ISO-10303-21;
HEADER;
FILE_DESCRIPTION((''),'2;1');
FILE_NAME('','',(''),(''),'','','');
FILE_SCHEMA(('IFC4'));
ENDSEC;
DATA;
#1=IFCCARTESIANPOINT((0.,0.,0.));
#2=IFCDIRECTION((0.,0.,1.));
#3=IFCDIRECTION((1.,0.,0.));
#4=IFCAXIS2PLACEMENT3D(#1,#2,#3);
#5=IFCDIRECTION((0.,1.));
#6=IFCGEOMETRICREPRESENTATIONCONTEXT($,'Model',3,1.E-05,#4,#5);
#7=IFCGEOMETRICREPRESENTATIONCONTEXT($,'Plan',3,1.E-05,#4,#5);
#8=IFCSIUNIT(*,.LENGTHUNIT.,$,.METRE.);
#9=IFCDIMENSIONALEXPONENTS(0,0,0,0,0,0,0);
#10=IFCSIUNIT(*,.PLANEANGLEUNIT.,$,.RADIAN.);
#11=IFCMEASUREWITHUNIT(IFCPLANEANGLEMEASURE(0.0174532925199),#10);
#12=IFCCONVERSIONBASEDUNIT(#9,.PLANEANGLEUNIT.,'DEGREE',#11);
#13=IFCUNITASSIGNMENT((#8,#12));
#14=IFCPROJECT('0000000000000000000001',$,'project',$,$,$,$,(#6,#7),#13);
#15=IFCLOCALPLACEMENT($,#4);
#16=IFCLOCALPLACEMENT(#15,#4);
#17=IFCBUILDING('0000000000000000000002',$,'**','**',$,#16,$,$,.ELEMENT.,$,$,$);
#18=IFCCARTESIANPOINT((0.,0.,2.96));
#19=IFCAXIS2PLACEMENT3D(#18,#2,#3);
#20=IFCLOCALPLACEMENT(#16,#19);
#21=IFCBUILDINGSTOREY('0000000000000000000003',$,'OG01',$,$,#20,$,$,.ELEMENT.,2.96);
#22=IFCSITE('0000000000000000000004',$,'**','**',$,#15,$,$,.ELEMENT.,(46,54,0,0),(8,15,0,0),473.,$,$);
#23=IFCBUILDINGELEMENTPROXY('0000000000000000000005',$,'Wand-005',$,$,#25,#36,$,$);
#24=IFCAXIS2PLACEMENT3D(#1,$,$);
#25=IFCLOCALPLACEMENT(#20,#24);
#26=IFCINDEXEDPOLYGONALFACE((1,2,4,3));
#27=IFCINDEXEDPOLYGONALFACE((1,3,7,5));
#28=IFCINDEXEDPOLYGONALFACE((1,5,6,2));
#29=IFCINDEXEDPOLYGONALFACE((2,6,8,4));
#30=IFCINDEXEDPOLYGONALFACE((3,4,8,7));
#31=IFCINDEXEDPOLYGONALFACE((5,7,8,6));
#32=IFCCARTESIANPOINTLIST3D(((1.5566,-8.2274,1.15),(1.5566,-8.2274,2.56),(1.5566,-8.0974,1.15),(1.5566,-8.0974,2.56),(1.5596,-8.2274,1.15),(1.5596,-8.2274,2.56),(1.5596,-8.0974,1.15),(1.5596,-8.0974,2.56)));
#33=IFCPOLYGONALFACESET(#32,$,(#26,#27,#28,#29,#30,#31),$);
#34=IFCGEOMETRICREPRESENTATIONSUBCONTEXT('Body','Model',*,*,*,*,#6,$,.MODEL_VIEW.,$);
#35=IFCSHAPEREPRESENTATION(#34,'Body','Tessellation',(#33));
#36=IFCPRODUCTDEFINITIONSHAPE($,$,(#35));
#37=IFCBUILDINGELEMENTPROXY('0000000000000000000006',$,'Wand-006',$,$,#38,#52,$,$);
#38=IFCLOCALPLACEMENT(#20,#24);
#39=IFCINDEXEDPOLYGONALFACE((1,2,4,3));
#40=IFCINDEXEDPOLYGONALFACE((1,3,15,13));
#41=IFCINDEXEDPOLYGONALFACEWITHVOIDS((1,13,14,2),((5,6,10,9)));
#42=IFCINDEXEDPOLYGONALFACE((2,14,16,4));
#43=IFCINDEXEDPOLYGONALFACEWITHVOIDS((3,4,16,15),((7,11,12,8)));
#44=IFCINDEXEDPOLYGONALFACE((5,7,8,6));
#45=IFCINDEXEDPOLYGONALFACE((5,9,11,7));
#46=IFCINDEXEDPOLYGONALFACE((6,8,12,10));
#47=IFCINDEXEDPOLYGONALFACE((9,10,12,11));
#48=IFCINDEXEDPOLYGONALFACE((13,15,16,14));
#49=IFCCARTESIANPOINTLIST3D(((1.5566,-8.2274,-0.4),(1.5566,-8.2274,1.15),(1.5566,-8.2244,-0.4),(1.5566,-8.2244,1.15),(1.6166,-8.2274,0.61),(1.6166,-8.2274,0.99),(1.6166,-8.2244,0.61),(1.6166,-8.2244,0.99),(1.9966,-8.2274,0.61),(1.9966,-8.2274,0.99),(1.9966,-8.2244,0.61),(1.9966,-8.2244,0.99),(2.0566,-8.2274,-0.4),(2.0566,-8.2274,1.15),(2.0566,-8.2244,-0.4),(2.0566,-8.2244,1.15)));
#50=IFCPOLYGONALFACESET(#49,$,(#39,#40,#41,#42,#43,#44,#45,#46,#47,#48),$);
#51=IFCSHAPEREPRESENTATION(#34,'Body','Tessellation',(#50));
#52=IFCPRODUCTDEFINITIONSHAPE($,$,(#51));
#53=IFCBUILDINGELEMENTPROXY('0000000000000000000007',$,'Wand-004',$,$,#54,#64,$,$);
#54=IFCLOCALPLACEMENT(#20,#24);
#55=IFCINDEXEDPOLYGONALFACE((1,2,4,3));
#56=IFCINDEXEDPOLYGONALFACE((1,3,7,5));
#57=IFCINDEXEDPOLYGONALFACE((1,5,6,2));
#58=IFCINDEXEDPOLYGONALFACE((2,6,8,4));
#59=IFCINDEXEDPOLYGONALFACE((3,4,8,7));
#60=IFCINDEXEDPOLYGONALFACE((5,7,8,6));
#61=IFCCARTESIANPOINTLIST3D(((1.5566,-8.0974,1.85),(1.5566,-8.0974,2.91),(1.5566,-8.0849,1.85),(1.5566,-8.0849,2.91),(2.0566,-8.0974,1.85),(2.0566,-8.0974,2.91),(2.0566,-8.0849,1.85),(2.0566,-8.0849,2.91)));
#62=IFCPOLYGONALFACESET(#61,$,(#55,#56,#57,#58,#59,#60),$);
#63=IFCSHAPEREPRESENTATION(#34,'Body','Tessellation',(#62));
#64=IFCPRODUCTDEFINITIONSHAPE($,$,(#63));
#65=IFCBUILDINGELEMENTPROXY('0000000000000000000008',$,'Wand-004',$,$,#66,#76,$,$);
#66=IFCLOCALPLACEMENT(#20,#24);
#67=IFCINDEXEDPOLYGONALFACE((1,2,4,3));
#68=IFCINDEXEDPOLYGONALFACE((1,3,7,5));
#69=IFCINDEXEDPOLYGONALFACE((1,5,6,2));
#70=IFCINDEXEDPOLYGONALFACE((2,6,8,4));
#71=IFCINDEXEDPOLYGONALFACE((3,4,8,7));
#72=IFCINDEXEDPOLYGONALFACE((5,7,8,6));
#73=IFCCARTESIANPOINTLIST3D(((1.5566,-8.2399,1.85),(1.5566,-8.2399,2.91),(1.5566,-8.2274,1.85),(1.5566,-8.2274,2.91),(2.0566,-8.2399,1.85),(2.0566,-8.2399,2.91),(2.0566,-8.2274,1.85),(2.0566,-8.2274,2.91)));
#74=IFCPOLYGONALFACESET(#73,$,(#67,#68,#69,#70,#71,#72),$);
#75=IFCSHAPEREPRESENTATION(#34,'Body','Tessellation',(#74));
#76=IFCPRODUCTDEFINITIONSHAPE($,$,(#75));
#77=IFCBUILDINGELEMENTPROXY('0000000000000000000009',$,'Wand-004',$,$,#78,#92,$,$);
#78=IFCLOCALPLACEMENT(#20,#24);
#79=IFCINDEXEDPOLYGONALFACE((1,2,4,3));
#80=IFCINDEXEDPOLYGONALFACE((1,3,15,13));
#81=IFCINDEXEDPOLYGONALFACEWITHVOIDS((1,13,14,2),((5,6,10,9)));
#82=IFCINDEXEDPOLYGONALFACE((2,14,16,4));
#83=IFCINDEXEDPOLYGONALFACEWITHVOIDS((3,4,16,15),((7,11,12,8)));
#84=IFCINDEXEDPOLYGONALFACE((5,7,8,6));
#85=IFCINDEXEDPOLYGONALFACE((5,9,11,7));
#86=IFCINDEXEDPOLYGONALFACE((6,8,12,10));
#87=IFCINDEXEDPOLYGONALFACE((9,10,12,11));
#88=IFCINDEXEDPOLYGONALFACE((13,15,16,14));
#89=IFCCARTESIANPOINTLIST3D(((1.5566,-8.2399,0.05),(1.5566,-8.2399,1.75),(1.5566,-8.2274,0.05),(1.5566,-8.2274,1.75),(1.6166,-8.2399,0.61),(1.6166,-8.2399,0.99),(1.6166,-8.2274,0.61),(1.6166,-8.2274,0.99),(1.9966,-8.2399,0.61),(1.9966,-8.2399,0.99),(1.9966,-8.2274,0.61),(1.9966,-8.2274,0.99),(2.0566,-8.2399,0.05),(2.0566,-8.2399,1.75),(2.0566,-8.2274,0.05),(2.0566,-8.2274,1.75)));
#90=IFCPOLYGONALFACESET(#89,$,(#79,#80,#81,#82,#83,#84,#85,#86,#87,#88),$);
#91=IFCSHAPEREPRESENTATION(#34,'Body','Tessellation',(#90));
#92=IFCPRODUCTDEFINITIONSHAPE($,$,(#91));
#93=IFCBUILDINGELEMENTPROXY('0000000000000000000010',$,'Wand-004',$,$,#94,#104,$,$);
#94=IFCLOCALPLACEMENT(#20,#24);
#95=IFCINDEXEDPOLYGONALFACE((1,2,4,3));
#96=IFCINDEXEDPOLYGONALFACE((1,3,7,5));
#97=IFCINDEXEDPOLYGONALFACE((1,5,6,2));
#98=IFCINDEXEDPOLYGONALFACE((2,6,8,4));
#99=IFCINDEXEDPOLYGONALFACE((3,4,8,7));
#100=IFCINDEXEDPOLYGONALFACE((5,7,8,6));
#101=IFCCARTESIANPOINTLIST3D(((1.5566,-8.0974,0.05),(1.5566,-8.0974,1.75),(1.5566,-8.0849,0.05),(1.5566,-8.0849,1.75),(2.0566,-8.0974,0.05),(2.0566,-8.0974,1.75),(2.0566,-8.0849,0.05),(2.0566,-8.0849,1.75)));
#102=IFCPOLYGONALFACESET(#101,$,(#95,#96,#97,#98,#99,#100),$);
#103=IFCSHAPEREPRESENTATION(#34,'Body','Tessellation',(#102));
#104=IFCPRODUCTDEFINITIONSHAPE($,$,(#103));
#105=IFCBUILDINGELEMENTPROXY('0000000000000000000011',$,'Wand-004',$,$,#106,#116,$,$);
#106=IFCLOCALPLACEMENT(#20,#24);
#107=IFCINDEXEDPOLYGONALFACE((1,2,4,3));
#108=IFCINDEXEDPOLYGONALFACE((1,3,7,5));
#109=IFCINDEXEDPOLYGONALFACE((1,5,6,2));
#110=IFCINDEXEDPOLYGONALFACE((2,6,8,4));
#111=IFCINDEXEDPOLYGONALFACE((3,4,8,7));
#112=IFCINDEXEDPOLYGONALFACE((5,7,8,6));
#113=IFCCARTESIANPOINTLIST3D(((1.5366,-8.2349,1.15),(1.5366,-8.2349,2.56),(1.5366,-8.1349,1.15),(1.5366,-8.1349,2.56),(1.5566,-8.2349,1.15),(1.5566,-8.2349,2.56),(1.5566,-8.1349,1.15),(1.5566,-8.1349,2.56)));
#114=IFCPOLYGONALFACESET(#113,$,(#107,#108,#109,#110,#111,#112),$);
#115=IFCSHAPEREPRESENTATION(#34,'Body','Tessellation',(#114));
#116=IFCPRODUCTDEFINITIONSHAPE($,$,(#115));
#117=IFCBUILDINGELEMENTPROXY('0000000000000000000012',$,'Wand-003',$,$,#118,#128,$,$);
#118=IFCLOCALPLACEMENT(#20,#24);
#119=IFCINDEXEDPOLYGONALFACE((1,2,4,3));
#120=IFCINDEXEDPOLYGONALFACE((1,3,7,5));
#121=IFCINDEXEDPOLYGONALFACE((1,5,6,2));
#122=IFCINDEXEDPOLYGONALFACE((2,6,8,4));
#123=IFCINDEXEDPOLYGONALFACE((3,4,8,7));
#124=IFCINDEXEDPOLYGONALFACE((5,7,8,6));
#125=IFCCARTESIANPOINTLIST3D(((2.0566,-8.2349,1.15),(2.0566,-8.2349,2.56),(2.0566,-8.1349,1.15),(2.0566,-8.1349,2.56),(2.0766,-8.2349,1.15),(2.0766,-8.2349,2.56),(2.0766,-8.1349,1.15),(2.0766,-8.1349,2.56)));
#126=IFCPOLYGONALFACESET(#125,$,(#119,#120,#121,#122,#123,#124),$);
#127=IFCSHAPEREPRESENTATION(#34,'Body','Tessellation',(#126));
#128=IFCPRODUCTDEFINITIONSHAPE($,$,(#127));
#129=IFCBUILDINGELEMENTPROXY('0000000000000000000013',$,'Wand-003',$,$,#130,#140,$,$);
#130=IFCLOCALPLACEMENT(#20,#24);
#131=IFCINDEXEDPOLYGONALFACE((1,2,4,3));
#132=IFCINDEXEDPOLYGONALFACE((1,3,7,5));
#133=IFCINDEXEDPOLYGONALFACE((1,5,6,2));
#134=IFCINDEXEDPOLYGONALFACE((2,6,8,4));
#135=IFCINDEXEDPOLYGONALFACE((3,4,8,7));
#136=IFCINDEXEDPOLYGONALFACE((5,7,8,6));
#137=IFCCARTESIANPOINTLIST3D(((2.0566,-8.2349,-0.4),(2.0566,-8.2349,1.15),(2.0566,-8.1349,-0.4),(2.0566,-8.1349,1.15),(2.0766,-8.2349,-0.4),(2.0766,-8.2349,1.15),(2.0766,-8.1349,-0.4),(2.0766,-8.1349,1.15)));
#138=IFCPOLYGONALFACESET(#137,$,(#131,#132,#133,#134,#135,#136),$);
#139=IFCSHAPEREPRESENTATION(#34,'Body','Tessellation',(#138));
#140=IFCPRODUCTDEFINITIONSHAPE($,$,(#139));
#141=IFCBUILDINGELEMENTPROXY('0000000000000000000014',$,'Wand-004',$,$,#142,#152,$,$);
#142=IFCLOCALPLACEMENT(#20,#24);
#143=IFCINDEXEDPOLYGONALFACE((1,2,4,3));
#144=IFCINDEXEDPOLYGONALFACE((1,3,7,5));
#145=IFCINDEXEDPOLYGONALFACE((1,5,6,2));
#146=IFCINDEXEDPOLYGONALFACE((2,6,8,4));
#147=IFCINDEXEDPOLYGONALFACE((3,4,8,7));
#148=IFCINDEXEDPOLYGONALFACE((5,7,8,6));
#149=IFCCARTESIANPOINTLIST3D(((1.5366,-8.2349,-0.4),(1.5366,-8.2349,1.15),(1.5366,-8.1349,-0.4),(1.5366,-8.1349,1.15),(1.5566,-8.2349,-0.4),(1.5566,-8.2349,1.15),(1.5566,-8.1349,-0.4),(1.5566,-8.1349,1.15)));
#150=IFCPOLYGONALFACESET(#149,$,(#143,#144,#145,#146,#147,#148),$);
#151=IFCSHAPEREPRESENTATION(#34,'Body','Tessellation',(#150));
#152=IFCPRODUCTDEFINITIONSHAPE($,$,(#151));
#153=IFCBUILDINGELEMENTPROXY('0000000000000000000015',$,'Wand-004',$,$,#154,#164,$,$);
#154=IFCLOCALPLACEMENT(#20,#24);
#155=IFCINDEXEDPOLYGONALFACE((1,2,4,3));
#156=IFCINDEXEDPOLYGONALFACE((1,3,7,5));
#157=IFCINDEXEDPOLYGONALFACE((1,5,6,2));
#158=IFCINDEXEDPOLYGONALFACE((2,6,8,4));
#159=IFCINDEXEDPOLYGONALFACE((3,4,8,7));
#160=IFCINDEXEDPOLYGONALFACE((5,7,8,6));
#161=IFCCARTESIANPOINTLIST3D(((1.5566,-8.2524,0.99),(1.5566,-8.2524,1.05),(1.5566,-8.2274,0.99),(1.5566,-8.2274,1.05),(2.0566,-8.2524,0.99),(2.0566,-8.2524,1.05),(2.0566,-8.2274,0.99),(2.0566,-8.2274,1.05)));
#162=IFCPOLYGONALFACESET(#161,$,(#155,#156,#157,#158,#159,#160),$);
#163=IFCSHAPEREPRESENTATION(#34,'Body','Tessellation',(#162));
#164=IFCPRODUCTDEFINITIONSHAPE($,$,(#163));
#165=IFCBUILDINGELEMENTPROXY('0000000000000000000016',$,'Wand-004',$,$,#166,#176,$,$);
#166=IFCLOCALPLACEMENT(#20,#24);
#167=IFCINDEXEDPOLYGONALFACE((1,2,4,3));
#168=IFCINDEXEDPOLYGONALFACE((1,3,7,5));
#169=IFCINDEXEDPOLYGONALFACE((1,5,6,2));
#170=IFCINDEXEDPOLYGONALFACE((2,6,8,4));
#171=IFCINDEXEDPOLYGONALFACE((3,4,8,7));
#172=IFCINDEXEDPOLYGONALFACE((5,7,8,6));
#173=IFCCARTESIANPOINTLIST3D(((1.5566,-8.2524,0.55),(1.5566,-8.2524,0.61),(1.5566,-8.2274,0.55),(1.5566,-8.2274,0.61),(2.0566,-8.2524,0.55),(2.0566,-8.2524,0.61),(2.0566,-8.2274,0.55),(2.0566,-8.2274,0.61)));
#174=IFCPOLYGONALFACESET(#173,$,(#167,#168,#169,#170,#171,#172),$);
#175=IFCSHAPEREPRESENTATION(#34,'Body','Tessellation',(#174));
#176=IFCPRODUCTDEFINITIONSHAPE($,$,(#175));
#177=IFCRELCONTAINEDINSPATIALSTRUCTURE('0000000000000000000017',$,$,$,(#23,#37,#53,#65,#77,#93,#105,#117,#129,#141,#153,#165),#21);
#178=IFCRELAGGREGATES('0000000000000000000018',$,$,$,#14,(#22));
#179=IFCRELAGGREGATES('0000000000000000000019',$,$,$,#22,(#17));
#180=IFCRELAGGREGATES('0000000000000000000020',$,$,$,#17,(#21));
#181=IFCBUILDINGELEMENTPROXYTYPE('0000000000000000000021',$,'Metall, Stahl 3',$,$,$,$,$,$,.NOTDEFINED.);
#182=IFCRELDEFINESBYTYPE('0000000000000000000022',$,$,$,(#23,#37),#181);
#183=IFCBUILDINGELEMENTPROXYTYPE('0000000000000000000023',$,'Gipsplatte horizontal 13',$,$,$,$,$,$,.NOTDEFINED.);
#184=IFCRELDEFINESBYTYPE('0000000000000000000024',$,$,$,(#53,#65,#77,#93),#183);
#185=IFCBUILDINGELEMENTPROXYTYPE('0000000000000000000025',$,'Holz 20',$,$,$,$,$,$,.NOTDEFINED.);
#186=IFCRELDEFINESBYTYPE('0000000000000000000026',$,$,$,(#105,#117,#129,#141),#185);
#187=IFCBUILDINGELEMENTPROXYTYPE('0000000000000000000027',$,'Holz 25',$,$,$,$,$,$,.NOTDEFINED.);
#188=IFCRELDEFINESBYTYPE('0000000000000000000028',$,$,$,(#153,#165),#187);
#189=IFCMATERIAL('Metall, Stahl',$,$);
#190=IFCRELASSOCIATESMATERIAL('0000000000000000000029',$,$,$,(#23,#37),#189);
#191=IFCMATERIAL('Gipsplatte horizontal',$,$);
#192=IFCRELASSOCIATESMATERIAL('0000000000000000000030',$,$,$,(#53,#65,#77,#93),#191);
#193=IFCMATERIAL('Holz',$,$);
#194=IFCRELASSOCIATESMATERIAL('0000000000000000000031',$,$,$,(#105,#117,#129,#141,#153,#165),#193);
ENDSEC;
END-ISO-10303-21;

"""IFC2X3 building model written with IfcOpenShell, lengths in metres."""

from ifc_helpers import new_model, entity, si_unit, converted_unit, direction, frame, origin_with_axes, origin_2d_with_axis, place, context, subcontext, project, spatial, polyline, rectangle, outline, extrude, material, type_object, element, save


model = new_model("IFC2X3")

# Units and contexts
model_context = context("Model", 3, precision=1e-05, world=origin_with_axes(), true_north=direction((0.0, 1.0)))
plan_context = context("Plan", 3, precision=1e-05, world=origin_with_axes(), true_north=direction((0.0, 1.0)))
body_context = subcontext(model_context, "Body", "Model", "MODEL_VIEW")
ifc_project = project(units=[si_unit("LENGTHUNIT", "METRE"), converted_unit("PLANEANGLEUNIT", "DEGREE", entity("IfcPlaneAngleMeasure", 0.0174532925199), si_unit("PLANEANGLEUNIT", "RADIAN"), dimensions=[0, 0, 0, 0, 0, 0, 0])], contexts=[model_context, plan_context])

# Site, building, storey
site_placement = place(None, origin_with_axes())
site = spatial("IfcSite", under=ifc_project, at=site_placement, Name="**", Description="**", CompositionType="ELEMENT", RefLatitude=(46, 54, 0, 0), RefLongitude=(8, 15, 0, 0), RefElevation=473.0)
building_placement = place(site_placement, origin_with_axes())
building = spatial("IfcBuilding", under=site, at=building_placement, Name="**", Description="**", CompositionType="ELEMENT")
storey_placement = place(building_placement, frame((0.0, 0.0, 2.96), z_axis=(0.0, 0.0, 1.0), x_axis=(1.0, 0.0, 0.0)))
storey = spatial("IfcBuildingStorey", under=building, at=storey_placement, Name="OG01", CompositionType="ELEMENT", Elevation=2.96)

# Building element proxy
ifc_material_1 = material(Name="Metall, Stahl")
building_element_proxy_type_1 = type_object("IfcBuildingElementProxyType", Name="Metall, Stahl 3", PredefinedType="NOTDEFINED")
proxy_1_placement = place(storey_placement, frame((1.5566, -8.0974, 1.15), z_axis=(0.0, 0.0, 1.0), x_axis=(0.0, -1.0, 0.0)))
element("IfcBuildingElementProxy", 1, at=proxy_1_placement, inside=storey, type_object=building_element_proxy_type_1, material=ifc_material_1, Name="Wand-005", context=body_context, shape_type="SweptSolid", body=[
    extrude(outline(polyline([(0.0, 0.0), (0.13, 0.0), (0.13, 0.003), (0.0, 0.003), (0.0, 0.0)])), origin_with_axes(), (0.0, 0.0, 1.0), 1.41),
])

# Building element proxy, opening
proxy_2_placement = place(storey_placement, frame((1.5566, -8.2274, -0.4), z_axis=(0.0, 0.0, 1.0), x_axis=(1.0, 0.0, 0.0)))
proxy_2 = element("IfcBuildingElementProxy", 2, at=proxy_2_placement, inside=storey, type_object=building_element_proxy_type_1, material=ifc_material_1, Name="Wand-006", context=body_context, shape_type="SweptSolid", body=[
    extrude(outline(polyline([(0.0, 0.0), (0.5, 0.0), (0.5, 0.003), (0.0, 0.003), (0.0, 0.0)])), origin_with_axes(), (0.0, 0.0, 1.0), 1.55),
])
opening_1_placement = place(proxy_2_placement, frame((-1.5566, 8.2274, -2.56), z_axis=(0.0, 0.0, 1.0), x_axis=(1.0, 0.0, 0.0)))
element("IfcOpeningElement", 3, at=opening_1_placement, cuts=proxy_2, context=body_context, shape_type="SweptSolid", body=[
    extrude(rectangle(XDim=0.38, YDim=0.38, at=origin_2d_with_axis()), frame((1.8066, -8.2524, 3.76), z_axis=(0.0, -1.0, 0.0), x_axis=(1.0, 0.0, 0.0)), (0.0, 0.0, -1.0), 0.031),
])

# Building element proxies
ifc_material_2 = material(Name="Gipsplatte horizontal")
building_element_proxy_type_2 = type_object("IfcBuildingElementProxyType", Name="Gipsplatte horizontal 13", PredefinedType="NOTDEFINED")
proxy_3_placement = place(storey_placement, frame((1.5566, -8.0849, 1.85), z_axis=(0.0, 0.0, 1.0), x_axis=(1.0, 0.0, 0.0)))
element("IfcBuildingElementProxy", 4, at=proxy_3_placement, inside=storey, type_object=building_element_proxy_type_2, material=ifc_material_2, Name="Wand-004", context=body_context, shape_type="SweptSolid", body=[
    extrude(outline(polyline([(0.0, -0.0125), (0.5, -0.0125), (0.5, 0.0), (0.0, 0.0), (0.0, -0.0125)])), origin_with_axes(), (0.0, 0.0, 1.0), 1.06),
])
proxy_4_placement = place(storey_placement, frame((1.5566, -8.2399, 1.85), z_axis=(0.0, 0.0, 1.0), x_axis=(1.0, 0.0, 0.0)))
element("IfcBuildingElementProxy", 5, at=proxy_4_placement, inside=storey, type_object=building_element_proxy_type_2, material=ifc_material_2, Name="Wand-004", context=body_context, shape_type="SweptSolid", body=[
    extrude(outline(polyline([(0.0, 0.0), (0.5, 0.0), (0.5, 0.0125), (0.0, 0.0125), (0.0, 0.0)])), origin_with_axes(), (0.0, 0.0, 1.0), 1.06),
])

# Building element proxy, opening
proxy_5_placement = place(storey_placement, frame((1.5566, -8.2399, 0.05), z_axis=(0.0, 0.0, 1.0), x_axis=(1.0, 0.0, 0.0)))
proxy_5 = element("IfcBuildingElementProxy", 6, at=proxy_5_placement, inside=storey, type_object=building_element_proxy_type_2, material=ifc_material_2, Name="Wand-004", context=body_context, shape_type="SweptSolid", body=[
    extrude(outline(polyline([(0.0, 0.0), (0.5, 0.0), (0.5, 0.0125), (0.0, 0.0125), (0.0, 0.0)])), origin_with_axes(), (0.0, 0.0, 1.0), 1.7),
])
opening_2_placement = place(proxy_5_placement, frame((-1.5566, 8.2399, -3.01), z_axis=(0.0, 0.0, 1.0), x_axis=(1.0, 0.0, 0.0)))
element("IfcOpeningElement", 7, at=opening_2_placement, cuts=proxy_5, context=body_context, shape_type="SweptSolid", body=[
    extrude(rectangle(XDim=0.38, YDim=0.38, at=origin_2d_with_axis()), frame((1.8066, -8.2524, 3.76), z_axis=(0.0, -1.0, 0.0), x_axis=(1.0, 0.0, 0.0)), (0.0, 0.0, -1.0), 0.0375),
])

# Building element proxies
proxy_6_placement = place(storey_placement, frame((1.5566, -8.0849, 0.05), z_axis=(0.0, 0.0, 1.0), x_axis=(1.0, 0.0, 0.0)))
element("IfcBuildingElementProxy", 8, at=proxy_6_placement, inside=storey, type_object=building_element_proxy_type_2, material=ifc_material_2, Name="Wand-004", context=body_context, shape_type="SweptSolid", body=[
    extrude(outline(polyline([(0.0, -0.0125), (0.5, -0.0125), (0.5, 0.0), (0.0, 0.0), (0.0, -0.0125)])), origin_with_axes(), (0.0, 0.0, 1.0), 1.7),
])
ifc_material_3 = material(Name="Holz")
building_element_proxy_type_3 = type_object("IfcBuildingElementProxyType", Name="Holz 20", PredefinedType="NOTDEFINED")
proxy_7_placement = place(storey_placement, frame((1.5366, -8.1349, 1.15), z_axis=(0.0, 0.0, 1.0), x_axis=(0.0, -1.0, 0.0)))
element("IfcBuildingElementProxy", 9, at=proxy_7_placement, inside=storey, type_object=building_element_proxy_type_3, material=ifc_material_3, Name="Wand-004", context=body_context, shape_type="SweptSolid", body=[
    extrude(outline(polyline([(0.0, 0.0), (0.1, 0.0), (0.1, 0.02), (0.0, 0.02), (0.0, 0.0)])), origin_with_axes(), (0.0, 0.0, 1.0), 1.41),
])
proxy_8_placement = place(storey_placement, frame((2.0766, -8.1349, 1.15), z_axis=(0.0, 0.0, 1.0), x_axis=(0.0, -1.0, 0.0)))
element("IfcBuildingElementProxy", 10, at=proxy_8_placement, inside=storey, type_object=building_element_proxy_type_3, material=ifc_material_3, Name="Wand-003", context=body_context, shape_type="SweptSolid", body=[
    extrude(outline(polyline([(0.0, -0.02), (0.1, -0.02), (0.1, 0.0), (0.0, 0.0), (0.0, -0.02)])), origin_with_axes(), (0.0, 0.0, 1.0), 1.41),
])
proxy_9_placement = place(storey_placement, frame((2.0766, -8.1349, -0.4), z_axis=(0.0, 0.0, 1.0), x_axis=(0.0, -1.0, 0.0)))
element("IfcBuildingElementProxy", 11, at=proxy_9_placement, inside=storey, type_object=building_element_proxy_type_3, material=ifc_material_3, Name="Wand-003", context=body_context, shape_type="SweptSolid", body=[
    extrude(outline(polyline([(0.0, -0.02), (0.1, -0.02), (0.1, 0.0), (0.0, 0.0), (0.0, -0.02)])), origin_with_axes(), (0.0, 0.0, 1.0), 1.55),
])
proxy_10_placement = place(storey_placement, frame((1.5366, -8.1349, -0.4), z_axis=(0.0, 0.0, 1.0), x_axis=(0.0, -1.0, 0.0)))
element("IfcBuildingElementProxy", 12, at=proxy_10_placement, inside=storey, type_object=building_element_proxy_type_3, material=ifc_material_3, Name="Wand-004", context=body_context, shape_type="SweptSolid", body=[
    extrude(outline(polyline([(0.0, 0.0), (0.1, 0.0), (0.1, 0.02), (0.0, 0.02), (0.0, 0.0)])), origin_with_axes(), (0.0, 0.0, 1.0), 1.55),
])
building_element_proxy_type_4 = type_object("IfcBuildingElementProxyType", Name="Holz 25", PredefinedType="NOTDEFINED")
for number, where, z_axis, x_axis, name in (
    (13, (2.0566, -8.2274, 0.99), (0.0, 0.0, 1.0), (-1.0, 0.0, 0.0), "Wand-004"),
    (14, (2.0566, -8.2274, 0.55), (0.0, 0.0, 1.0), (-1.0, 0.0, 0.0), "Wand-004"),
):
    element("IfcBuildingElementProxy", number, at=place(storey_placement, frame(where, z_axis=z_axis, x_axis=x_axis)), inside=storey, type_object=building_element_proxy_type_4, material=ifc_material_3, Name=name, context=body_context, shape_type="SweptSolid", body=[
        extrude(outline(polyline([(0.0, 0.0), (0.5, 0.0), (0.5, 0.025), (0.0, 0.025), (0.0, 0.0)])), origin_with_axes(), (0.0, 0.0, 1.0), 0.06),
    ])

save(model, "model.ifc")
